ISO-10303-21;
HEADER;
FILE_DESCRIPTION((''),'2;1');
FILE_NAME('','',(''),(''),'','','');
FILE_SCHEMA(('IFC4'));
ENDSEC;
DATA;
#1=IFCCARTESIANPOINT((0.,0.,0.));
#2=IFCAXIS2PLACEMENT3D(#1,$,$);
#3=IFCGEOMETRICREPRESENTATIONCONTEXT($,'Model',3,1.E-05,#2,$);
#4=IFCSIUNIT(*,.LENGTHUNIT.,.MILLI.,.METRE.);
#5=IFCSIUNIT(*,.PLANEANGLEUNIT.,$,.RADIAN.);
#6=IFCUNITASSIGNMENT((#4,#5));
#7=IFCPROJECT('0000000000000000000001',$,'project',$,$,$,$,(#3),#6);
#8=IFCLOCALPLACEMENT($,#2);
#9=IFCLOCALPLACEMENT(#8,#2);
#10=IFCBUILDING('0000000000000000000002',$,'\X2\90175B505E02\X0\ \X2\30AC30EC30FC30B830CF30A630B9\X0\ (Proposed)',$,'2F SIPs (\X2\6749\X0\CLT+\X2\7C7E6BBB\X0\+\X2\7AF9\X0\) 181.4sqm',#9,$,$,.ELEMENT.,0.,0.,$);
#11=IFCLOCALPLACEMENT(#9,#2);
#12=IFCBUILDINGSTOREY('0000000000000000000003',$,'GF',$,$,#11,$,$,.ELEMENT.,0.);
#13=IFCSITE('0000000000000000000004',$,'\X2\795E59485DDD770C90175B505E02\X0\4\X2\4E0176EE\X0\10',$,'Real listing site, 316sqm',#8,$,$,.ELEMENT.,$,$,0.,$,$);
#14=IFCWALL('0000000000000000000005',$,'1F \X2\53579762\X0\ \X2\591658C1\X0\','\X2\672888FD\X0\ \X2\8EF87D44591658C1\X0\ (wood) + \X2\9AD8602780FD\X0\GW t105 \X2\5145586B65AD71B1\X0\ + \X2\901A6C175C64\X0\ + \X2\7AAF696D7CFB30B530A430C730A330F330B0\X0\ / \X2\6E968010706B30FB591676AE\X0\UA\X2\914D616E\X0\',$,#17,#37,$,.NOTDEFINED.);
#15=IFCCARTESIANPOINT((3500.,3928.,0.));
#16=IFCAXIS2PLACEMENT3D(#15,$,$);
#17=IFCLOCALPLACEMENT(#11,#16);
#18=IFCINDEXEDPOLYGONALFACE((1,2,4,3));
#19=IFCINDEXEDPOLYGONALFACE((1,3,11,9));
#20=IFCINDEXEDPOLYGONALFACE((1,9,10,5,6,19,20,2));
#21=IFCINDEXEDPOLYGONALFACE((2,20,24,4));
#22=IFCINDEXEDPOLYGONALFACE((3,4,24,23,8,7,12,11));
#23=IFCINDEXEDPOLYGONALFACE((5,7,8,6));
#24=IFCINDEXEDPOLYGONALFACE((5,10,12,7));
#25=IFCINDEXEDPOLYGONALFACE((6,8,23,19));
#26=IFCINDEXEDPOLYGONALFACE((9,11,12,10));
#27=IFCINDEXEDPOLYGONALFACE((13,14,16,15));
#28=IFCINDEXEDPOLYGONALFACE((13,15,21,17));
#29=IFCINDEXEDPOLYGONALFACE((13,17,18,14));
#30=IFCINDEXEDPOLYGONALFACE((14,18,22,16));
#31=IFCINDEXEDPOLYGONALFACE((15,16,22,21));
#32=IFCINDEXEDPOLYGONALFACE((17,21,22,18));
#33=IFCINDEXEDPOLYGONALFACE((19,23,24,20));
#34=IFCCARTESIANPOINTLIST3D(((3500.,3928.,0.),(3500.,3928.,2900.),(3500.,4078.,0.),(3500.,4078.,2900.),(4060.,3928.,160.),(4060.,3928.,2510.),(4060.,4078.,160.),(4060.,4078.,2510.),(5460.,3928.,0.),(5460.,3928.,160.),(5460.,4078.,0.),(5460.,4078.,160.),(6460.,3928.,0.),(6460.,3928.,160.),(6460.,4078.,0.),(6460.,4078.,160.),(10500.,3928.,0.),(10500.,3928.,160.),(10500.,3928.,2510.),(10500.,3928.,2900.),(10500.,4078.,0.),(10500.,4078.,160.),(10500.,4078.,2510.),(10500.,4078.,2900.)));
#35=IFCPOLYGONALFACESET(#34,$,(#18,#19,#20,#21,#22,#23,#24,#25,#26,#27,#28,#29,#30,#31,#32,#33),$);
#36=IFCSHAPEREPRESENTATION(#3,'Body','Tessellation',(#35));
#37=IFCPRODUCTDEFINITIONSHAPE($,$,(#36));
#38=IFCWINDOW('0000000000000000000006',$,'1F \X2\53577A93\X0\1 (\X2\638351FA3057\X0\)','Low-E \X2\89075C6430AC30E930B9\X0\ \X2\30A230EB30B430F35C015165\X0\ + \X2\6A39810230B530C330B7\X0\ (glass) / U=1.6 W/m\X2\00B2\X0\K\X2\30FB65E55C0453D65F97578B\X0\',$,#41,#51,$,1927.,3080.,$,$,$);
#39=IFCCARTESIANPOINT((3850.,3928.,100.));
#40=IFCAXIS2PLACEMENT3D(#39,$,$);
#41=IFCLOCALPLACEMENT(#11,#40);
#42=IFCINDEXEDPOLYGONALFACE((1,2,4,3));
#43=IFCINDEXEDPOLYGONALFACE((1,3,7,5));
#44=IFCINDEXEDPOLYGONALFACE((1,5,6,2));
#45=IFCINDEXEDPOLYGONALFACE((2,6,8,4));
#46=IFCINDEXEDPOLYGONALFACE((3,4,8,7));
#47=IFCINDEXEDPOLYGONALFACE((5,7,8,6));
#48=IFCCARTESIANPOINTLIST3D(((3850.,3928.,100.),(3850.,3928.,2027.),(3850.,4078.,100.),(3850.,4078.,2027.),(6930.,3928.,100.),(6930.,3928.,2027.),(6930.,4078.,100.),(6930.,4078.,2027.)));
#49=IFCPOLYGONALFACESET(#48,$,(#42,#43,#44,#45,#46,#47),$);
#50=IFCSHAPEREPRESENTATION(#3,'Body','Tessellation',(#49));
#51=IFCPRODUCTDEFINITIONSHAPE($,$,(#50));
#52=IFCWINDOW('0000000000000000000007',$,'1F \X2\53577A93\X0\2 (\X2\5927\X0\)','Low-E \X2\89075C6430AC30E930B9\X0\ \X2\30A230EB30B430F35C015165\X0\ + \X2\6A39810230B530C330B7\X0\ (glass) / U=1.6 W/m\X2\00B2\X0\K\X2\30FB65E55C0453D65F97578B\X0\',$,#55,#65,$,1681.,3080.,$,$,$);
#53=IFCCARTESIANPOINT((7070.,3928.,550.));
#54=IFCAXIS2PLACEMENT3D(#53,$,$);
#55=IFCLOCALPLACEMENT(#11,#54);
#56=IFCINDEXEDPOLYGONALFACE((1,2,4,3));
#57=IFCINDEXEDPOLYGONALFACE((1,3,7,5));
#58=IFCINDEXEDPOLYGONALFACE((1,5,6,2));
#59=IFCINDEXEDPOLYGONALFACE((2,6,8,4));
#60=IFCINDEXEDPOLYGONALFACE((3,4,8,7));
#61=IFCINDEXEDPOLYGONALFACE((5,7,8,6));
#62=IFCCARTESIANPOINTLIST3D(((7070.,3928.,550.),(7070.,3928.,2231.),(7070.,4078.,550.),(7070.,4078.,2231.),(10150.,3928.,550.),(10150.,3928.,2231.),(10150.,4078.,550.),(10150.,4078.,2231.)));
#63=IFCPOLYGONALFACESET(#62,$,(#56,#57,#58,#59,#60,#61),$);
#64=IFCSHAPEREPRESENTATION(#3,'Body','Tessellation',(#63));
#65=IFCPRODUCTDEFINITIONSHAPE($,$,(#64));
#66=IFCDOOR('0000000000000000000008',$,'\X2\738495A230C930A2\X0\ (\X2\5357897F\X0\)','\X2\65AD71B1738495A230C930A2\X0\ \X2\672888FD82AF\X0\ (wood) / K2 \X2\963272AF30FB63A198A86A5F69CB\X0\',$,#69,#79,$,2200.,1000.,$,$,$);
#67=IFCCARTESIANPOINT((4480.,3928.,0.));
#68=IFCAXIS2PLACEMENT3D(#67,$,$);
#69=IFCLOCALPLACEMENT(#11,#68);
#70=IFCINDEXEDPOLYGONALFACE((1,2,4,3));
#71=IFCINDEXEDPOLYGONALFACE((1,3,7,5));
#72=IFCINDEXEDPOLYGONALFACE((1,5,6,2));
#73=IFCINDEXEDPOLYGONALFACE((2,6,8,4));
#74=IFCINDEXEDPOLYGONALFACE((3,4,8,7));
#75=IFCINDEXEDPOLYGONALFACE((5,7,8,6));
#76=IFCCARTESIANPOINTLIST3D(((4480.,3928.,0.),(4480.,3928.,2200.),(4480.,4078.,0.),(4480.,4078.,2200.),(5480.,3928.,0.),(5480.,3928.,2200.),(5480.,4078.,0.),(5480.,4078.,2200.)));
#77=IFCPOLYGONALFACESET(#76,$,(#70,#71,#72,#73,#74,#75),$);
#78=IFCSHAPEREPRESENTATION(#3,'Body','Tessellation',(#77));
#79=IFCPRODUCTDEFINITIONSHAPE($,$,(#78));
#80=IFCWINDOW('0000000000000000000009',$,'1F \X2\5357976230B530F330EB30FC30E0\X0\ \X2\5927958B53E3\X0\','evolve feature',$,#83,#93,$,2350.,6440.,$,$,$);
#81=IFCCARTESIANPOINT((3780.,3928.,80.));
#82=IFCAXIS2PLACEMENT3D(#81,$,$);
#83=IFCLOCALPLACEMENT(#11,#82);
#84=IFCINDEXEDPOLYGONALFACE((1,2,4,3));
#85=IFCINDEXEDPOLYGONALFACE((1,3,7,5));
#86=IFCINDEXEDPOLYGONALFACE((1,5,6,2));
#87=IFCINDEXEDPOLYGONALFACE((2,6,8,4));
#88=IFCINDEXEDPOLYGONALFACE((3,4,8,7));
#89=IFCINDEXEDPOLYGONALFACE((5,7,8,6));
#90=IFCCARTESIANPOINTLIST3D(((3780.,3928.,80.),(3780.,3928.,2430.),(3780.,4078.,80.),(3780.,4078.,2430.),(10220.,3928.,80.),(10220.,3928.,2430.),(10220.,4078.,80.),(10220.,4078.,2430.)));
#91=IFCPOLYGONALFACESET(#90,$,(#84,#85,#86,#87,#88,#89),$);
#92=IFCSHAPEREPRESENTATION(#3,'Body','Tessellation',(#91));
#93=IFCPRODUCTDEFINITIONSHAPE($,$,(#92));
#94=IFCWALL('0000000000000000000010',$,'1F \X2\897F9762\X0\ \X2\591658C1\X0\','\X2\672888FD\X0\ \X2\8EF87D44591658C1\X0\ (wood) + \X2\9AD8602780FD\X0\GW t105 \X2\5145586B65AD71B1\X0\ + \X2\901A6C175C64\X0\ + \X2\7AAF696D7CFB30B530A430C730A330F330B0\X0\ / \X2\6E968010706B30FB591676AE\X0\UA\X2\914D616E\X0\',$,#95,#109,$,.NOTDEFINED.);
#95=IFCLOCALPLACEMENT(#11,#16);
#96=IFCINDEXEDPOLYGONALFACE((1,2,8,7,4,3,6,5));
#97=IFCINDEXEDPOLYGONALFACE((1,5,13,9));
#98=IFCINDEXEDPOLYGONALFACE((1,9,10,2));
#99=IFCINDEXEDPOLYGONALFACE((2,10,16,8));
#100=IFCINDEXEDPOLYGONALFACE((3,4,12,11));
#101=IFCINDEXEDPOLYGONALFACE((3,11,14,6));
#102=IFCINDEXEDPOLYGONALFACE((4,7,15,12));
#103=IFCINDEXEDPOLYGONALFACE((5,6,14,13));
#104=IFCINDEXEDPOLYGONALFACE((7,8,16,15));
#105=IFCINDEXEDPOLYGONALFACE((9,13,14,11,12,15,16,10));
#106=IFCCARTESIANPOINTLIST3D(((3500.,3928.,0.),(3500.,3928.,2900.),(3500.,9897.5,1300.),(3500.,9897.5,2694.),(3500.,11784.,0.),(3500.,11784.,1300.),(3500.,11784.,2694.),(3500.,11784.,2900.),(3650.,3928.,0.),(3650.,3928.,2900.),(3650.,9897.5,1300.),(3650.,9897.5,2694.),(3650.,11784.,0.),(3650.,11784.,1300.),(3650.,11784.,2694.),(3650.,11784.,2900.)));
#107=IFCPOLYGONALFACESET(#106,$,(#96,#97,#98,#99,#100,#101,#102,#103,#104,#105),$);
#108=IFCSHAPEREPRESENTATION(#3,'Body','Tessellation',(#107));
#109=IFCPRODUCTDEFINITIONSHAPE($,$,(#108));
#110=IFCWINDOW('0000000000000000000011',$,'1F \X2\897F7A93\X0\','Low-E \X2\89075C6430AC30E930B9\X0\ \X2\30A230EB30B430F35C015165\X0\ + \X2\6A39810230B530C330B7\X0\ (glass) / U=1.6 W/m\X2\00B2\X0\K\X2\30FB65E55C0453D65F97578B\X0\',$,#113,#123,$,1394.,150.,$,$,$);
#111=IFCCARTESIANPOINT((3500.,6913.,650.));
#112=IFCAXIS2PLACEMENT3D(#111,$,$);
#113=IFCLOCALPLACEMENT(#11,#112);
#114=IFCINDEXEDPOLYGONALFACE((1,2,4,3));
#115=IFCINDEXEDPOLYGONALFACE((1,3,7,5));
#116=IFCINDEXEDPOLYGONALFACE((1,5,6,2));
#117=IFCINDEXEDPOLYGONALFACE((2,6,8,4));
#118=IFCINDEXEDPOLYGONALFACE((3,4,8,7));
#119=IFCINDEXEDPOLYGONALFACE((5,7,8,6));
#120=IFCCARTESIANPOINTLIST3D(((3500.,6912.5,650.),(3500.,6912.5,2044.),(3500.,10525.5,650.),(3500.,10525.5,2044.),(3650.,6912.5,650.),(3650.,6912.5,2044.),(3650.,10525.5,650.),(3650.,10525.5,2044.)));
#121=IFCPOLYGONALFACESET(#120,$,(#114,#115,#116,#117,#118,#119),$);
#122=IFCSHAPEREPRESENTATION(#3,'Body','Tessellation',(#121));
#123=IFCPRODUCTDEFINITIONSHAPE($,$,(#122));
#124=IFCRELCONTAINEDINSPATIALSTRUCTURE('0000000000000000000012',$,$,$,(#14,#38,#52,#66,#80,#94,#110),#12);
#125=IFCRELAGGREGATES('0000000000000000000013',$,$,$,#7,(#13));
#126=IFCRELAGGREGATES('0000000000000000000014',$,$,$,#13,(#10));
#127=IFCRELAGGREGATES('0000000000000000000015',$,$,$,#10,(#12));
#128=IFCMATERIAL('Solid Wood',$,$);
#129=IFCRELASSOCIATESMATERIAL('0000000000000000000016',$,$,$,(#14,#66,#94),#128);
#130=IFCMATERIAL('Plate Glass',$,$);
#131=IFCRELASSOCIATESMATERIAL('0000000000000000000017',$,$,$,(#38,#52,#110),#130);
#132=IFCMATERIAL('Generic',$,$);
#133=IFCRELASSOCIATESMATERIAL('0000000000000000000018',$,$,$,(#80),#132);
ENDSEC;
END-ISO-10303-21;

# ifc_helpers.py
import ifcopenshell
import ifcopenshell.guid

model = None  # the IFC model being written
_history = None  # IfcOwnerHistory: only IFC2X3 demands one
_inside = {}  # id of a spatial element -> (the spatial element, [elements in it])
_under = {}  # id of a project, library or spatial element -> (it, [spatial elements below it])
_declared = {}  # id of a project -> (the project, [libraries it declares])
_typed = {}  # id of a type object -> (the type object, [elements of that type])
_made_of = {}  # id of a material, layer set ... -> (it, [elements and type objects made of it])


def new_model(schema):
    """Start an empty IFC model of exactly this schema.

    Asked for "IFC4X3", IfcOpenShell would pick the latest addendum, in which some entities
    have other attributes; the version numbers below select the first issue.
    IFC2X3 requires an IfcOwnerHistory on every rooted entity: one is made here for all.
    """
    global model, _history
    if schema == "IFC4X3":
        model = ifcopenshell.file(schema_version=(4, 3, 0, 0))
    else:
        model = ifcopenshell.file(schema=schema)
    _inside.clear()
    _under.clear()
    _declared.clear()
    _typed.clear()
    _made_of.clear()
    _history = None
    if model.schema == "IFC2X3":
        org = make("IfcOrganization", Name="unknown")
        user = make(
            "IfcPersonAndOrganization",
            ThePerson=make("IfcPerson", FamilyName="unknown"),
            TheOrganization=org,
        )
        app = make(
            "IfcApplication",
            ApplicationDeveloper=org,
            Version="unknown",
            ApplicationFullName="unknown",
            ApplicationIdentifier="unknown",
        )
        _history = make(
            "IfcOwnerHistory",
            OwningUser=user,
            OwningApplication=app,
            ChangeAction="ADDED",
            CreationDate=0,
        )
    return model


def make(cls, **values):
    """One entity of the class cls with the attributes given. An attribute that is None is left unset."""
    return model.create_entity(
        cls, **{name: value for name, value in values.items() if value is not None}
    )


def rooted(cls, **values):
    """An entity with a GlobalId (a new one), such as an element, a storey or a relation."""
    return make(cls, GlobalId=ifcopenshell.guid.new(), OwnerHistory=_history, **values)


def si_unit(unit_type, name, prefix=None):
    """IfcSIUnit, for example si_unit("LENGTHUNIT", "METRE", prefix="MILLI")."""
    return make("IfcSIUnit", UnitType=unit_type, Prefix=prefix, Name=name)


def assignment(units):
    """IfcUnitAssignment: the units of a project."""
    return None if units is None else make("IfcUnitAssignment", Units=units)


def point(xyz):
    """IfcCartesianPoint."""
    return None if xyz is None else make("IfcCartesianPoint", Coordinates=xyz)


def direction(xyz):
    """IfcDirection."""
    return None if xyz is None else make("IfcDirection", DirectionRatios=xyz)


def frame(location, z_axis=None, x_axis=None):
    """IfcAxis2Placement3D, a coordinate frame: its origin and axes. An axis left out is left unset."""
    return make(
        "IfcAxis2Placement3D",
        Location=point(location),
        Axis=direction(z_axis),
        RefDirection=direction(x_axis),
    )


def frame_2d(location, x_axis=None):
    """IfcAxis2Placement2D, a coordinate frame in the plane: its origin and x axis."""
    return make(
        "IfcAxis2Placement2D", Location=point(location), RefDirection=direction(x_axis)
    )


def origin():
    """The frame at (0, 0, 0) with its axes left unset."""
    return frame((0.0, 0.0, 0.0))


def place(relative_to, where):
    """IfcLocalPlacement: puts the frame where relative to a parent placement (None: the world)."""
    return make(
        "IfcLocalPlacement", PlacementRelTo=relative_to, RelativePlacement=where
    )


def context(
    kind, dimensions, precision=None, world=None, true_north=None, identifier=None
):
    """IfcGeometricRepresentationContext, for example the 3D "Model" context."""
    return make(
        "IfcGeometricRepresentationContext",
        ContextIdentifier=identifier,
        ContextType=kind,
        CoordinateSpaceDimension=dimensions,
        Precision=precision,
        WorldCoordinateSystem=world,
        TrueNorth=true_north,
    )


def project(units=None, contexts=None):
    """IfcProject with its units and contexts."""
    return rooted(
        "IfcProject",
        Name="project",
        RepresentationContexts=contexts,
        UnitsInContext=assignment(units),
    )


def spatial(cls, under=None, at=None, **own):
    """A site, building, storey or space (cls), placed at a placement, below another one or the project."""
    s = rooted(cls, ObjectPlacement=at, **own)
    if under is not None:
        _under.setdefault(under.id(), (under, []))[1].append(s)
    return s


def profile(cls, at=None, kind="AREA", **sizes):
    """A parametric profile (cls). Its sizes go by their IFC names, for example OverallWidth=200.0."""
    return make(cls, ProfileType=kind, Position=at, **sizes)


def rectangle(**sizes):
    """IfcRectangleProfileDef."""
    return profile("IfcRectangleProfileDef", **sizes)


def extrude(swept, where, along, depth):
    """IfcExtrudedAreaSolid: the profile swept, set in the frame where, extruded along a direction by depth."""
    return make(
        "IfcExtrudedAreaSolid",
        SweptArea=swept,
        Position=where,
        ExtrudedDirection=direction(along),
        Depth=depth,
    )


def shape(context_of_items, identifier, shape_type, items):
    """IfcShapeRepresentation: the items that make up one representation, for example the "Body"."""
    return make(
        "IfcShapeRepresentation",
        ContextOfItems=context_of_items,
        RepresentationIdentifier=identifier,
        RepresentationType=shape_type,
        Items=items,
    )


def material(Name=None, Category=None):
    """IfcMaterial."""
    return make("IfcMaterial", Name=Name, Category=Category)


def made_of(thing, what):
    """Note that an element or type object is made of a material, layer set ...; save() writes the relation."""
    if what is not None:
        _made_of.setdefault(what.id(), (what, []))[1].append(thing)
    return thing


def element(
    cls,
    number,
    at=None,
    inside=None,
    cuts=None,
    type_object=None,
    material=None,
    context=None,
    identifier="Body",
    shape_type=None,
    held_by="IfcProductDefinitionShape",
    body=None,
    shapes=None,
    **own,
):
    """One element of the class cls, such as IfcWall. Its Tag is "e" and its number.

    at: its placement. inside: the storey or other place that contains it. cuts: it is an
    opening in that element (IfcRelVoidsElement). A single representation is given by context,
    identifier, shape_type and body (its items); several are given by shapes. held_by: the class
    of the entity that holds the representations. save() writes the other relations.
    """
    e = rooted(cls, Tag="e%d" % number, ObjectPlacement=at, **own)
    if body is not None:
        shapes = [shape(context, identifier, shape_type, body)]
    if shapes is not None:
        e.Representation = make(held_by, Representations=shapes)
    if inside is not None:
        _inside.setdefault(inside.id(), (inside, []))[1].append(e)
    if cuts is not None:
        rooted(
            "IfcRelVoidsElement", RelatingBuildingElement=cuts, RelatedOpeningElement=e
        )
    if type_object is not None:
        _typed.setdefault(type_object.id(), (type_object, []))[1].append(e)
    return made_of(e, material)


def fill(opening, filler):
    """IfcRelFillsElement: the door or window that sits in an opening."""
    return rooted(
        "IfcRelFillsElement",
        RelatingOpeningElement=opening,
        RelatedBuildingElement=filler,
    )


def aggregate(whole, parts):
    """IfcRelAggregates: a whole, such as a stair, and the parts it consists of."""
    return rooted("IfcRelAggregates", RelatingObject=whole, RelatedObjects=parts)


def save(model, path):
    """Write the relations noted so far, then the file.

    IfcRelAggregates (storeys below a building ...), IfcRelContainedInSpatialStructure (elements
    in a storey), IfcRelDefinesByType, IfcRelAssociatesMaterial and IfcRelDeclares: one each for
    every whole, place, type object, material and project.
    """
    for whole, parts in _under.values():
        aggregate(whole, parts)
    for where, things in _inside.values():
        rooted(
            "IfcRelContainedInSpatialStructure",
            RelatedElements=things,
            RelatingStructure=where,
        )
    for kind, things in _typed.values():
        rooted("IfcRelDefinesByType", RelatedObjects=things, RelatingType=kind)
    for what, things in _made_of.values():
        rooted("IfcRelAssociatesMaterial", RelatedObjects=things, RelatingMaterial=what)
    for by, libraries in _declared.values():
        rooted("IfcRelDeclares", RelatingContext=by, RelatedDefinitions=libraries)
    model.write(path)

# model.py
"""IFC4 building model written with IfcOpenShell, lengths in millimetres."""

from ifc_helpers import new_model, si_unit, frame, frame_2d, origin, place, context, project, spatial, rectangle, extrude, material, element, fill, save


model = new_model("IFC4")

# Units and contexts
model_context = context("Model", 3, precision=1e-05, world=origin())
ifc_project = project(units=[si_unit("LENGTHUNIT", "METRE", prefix="MILLI"), si_unit("PLANEANGLEUNIT", "RADIAN")], contexts=[model_context])

# Site, building, storey
site_placement = place(None, origin())
site = spatial("IfcSite", under=ifc_project, at=site_placement, Name="神奈川県逗子市4丁目10", ObjectType="Real listing site, 316sqm", CompositionType="ELEMENT", RefElevation=0.0)
building_placement = place(site_placement, origin())
building = spatial("IfcBuilding", under=site, at=building_placement, Name="逗子市 ガレージハウス (Proposed)", ObjectType="2F SIPs (杉CLT+籾殻+竹) 181.4sqm", CompositionType="ELEMENT", ElevationOfRefHeight=0.0, ElevationOfTerrain=0.0)
storey_placement = place(building_placement, origin())
storey = spatial("IfcBuildingStorey", under=building, at=storey_placement, Name="GF", CompositionType="ELEMENT", Elevation=0.0)

# Shared definitions
ifc_material_1 = material(Name="Solid Wood")
ifc_material_2 = material(Name="Generic")

# Wall, openings, windows, door
wall_1_placement = place(storey_placement, frame((3500.0, 3928.0, 0.0)))
wall_1 = element("IfcWall", 1, at=wall_1_placement, inside=storey, material=ifc_material_1, Name="1F 南面 外壁", Description="木製 軸組外壁 (wood) + 高性能GW t105 充填断熱 + 通気層 + 窯業系サイディング / 準耐火・外皮UA配慮", PredefinedType="NOTDEFINED", context=model_context, shape_type="SweptSolid", body=[
    extrude(rectangle(XDim=7000.0, YDim=150.0, at=frame_2d((3500.0, 75.0))), frame((3500.0, 3928.0, 0.0)), (0.0, 0.0, 1.0), 2900.0),
])
opening_1_placement = place(storey_placement, frame((3850.0, 3928.0, 100.0)))
opening_1 = element("IfcOpeningElement", 2, at=opening_1_placement, cuts=wall_1, PredefinedType="NOTDEFINED", context=model_context, shape_type="SweptSolid", body=[
    extrude(rectangle(XDim=3080.0, YDim=150.0, at=frame_2d((1540.0, 75.0))), frame((3850.0, 3928.0, 100.0)), (0.0, 0.0, 1.0), 1927.0),
])
opening_2_placement = place(storey_placement, frame((7070.0, 3928.0, 550.0)))
opening_2 = element("IfcOpeningElement", 3, at=opening_2_placement, cuts=wall_1, PredefinedType="NOTDEFINED", context=model_context, shape_type="SweptSolid", body=[
    extrude(rectangle(XDim=3080.0, YDim=150.0, at=frame_2d((1540.0, 75.0))), frame((7070.0, 3928.0, 550.0)), (0.0, 0.0, 1.0), 1681.0),
])
opening_3_placement = place(storey_placement, frame((4480.0, 3928.0, 0.0)))
opening_3 = element("IfcOpeningElement", 4, at=opening_3_placement, cuts=wall_1, PredefinedType="NOTDEFINED", context=model_context, shape_type="SweptSolid", body=[
    extrude(rectangle(XDim=1000.0, YDim=150.0, at=frame_2d((500.0, 75.0))), frame((4480.0, 3928.0, 0.0)), (0.0, 0.0, 1.0), 2200.0),
])
opening_4_placement = place(storey_placement, frame((3780.0, 3928.0, 80.0)))
opening_4 = element("IfcOpeningElement", 5, at=opening_4_placement, cuts=wall_1, PredefinedType="NOTDEFINED", context=model_context, shape_type="SweptSolid", body=[
    extrude(rectangle(XDim=6440.0, YDim=150.0, at=frame_2d((3220.0, 75.0))), frame((3780.0, 3928.0, 80.0)), (0.0, 0.0, 1.0), 2350.0),
])
ifc_material_3 = material(Name="Plate Glass")
window_1_placement = place(storey_placement, frame((3850.0, 3928.0, 100.0)))
window_1 = element("IfcWindow", 6, at=window_1_placement, inside=storey, material=ifc_material_3, Name="1F 南窓1 (掃出し)", Description="Low-E 複層ガラス アルゴン封入 + 樹脂サッシ (glass) / U=1.6 W/m²K・日射取得型", OverallHeight=1927.0, OverallWidth=3080.0, context=model_context, shape_type="SweptSolid", body=[
    extrude(rectangle(XDim=3080.0, YDim=150.0, at=frame_2d((1540.0, 75.0))), frame((3850.0, 3928.0, 100.0)), (0.0, 0.0, 1.0), 1927.0),
])
fill(opening_1, window_1)
window_2_placement = place(storey_placement, frame((7070.0, 3928.0, 550.0)))
window_2 = element("IfcWindow", 7, at=window_2_placement, inside=storey, material=ifc_material_3, Name="1F 南窓2 (大)", Description="Low-E 複層ガラス アルゴン封入 + 樹脂サッシ (glass) / U=1.6 W/m²K・日射取得型", OverallHeight=1681.0, OverallWidth=3080.0, context=model_context, shape_type="SweptSolid", body=[
    extrude(rectangle(XDim=3080.0, YDim=150.0, at=frame_2d((1540.0, 75.0))), frame((7070.0, 3928.0, 550.0)), (0.0, 0.0, 1.0), 1681.0),
])
fill(opening_2, window_2)
door_placement = place(storey_placement, frame((4480.0, 3928.0, 0.0)))
door = element("IfcDoor", 8, at=door_placement, inside=storey, material=ifc_material_1, Name="玄関ドア (南西)", Description="断熱玄関ドア 木製芯 (wood) / K2 防犯・採風機構", OverallHeight=2200.0, OverallWidth=1000.0, context=model_context, shape_type="SweptSolid", body=[
    extrude(rectangle(XDim=1000.0, YDim=150.0, at=frame_2d((500.0, 75.0))), frame((4480.0, 3928.0, 0.0)), (0.0, 0.0, 1.0), 2200.0),
])
fill(opening_3, door)
window_3_placement = place(storey_placement, frame((3780.0, 3928.0, 80.0)))
window_3 = element("IfcWindow", 9, at=window_3_placement, inside=storey, material=ifc_material_2, Name="1F 南面サンルーム 大開口", Description="evolve feature", OverallHeight=2350.0, OverallWidth=6440.0, context=model_context, shape_type="SweptSolid", body=[
    extrude(rectangle(XDim=6440.0, YDim=150.0, at=frame_2d((3220.0, 75.0))), frame((3780.0, 3928.0, 80.0)), (0.0, 0.0, 1.0), 2350.0),
])
fill(opening_4, window_3)

# Wall, opening, window
wall_2_placement = place(storey_placement, frame((3500.0, 3928.0, 0.0)))
wall_2 = element("IfcWall", 10, at=wall_2_placement, inside=storey, material=ifc_material_1, Name="1F 西面 外壁", Description="木製 軸組外壁 (wood) + 高性能GW t105 充填断熱 + 通気層 + 窯業系サイディング / 準耐火・外皮UA配慮", PredefinedType="NOTDEFINED", context=model_context, shape_type="SweptSolid", body=[
    extrude(rectangle(XDim=150.0, YDim=7856.0, at=frame_2d((75.0, 3928.0))), frame((3500.0, 3928.0, 0.0)), (0.0, 0.0, 1.0), 2900.0),
])
opening_5_placement = place(storey_placement, frame((3500.0, 6913.0, 650.0)))
opening_5 = element("IfcOpeningElement", 11, at=opening_5_placement, cuts=wall_2, PredefinedType="NOTDEFINED", context=model_context, shape_type="SweptSolid", body=[
    extrude(rectangle(XDim=150.0, YDim=3613.0, at=frame_2d((75.0, 1806.0))), frame((3500.0, 6913.0, 650.0)), (0.0, 0.0, 1.0), 1394.0),
])
window_4_placement = place(storey_placement, frame((3500.0, 6913.0, 650.0)))
window_4 = element("IfcWindow", 12, at=window_4_placement, inside=storey, material=ifc_material_3, Name="1F 西窓", Description="Low-E 複層ガラス アルゴン封入 + 樹脂サッシ (glass) / U=1.6 W/m²K・日射取得型", OverallHeight=1394.0, OverallWidth=150.0, context=model_context, shape_type="SweptSolid", body=[
    extrude(rectangle(XDim=150.0, YDim=3613.0, at=frame_2d((75.0, 1806.0))), frame((3500.0, 6913.0, 650.0)), (0.0, 0.0, 1.0), 1394.0),
])
fill(opening_5, window_4)

save(model, "model.ifc")
